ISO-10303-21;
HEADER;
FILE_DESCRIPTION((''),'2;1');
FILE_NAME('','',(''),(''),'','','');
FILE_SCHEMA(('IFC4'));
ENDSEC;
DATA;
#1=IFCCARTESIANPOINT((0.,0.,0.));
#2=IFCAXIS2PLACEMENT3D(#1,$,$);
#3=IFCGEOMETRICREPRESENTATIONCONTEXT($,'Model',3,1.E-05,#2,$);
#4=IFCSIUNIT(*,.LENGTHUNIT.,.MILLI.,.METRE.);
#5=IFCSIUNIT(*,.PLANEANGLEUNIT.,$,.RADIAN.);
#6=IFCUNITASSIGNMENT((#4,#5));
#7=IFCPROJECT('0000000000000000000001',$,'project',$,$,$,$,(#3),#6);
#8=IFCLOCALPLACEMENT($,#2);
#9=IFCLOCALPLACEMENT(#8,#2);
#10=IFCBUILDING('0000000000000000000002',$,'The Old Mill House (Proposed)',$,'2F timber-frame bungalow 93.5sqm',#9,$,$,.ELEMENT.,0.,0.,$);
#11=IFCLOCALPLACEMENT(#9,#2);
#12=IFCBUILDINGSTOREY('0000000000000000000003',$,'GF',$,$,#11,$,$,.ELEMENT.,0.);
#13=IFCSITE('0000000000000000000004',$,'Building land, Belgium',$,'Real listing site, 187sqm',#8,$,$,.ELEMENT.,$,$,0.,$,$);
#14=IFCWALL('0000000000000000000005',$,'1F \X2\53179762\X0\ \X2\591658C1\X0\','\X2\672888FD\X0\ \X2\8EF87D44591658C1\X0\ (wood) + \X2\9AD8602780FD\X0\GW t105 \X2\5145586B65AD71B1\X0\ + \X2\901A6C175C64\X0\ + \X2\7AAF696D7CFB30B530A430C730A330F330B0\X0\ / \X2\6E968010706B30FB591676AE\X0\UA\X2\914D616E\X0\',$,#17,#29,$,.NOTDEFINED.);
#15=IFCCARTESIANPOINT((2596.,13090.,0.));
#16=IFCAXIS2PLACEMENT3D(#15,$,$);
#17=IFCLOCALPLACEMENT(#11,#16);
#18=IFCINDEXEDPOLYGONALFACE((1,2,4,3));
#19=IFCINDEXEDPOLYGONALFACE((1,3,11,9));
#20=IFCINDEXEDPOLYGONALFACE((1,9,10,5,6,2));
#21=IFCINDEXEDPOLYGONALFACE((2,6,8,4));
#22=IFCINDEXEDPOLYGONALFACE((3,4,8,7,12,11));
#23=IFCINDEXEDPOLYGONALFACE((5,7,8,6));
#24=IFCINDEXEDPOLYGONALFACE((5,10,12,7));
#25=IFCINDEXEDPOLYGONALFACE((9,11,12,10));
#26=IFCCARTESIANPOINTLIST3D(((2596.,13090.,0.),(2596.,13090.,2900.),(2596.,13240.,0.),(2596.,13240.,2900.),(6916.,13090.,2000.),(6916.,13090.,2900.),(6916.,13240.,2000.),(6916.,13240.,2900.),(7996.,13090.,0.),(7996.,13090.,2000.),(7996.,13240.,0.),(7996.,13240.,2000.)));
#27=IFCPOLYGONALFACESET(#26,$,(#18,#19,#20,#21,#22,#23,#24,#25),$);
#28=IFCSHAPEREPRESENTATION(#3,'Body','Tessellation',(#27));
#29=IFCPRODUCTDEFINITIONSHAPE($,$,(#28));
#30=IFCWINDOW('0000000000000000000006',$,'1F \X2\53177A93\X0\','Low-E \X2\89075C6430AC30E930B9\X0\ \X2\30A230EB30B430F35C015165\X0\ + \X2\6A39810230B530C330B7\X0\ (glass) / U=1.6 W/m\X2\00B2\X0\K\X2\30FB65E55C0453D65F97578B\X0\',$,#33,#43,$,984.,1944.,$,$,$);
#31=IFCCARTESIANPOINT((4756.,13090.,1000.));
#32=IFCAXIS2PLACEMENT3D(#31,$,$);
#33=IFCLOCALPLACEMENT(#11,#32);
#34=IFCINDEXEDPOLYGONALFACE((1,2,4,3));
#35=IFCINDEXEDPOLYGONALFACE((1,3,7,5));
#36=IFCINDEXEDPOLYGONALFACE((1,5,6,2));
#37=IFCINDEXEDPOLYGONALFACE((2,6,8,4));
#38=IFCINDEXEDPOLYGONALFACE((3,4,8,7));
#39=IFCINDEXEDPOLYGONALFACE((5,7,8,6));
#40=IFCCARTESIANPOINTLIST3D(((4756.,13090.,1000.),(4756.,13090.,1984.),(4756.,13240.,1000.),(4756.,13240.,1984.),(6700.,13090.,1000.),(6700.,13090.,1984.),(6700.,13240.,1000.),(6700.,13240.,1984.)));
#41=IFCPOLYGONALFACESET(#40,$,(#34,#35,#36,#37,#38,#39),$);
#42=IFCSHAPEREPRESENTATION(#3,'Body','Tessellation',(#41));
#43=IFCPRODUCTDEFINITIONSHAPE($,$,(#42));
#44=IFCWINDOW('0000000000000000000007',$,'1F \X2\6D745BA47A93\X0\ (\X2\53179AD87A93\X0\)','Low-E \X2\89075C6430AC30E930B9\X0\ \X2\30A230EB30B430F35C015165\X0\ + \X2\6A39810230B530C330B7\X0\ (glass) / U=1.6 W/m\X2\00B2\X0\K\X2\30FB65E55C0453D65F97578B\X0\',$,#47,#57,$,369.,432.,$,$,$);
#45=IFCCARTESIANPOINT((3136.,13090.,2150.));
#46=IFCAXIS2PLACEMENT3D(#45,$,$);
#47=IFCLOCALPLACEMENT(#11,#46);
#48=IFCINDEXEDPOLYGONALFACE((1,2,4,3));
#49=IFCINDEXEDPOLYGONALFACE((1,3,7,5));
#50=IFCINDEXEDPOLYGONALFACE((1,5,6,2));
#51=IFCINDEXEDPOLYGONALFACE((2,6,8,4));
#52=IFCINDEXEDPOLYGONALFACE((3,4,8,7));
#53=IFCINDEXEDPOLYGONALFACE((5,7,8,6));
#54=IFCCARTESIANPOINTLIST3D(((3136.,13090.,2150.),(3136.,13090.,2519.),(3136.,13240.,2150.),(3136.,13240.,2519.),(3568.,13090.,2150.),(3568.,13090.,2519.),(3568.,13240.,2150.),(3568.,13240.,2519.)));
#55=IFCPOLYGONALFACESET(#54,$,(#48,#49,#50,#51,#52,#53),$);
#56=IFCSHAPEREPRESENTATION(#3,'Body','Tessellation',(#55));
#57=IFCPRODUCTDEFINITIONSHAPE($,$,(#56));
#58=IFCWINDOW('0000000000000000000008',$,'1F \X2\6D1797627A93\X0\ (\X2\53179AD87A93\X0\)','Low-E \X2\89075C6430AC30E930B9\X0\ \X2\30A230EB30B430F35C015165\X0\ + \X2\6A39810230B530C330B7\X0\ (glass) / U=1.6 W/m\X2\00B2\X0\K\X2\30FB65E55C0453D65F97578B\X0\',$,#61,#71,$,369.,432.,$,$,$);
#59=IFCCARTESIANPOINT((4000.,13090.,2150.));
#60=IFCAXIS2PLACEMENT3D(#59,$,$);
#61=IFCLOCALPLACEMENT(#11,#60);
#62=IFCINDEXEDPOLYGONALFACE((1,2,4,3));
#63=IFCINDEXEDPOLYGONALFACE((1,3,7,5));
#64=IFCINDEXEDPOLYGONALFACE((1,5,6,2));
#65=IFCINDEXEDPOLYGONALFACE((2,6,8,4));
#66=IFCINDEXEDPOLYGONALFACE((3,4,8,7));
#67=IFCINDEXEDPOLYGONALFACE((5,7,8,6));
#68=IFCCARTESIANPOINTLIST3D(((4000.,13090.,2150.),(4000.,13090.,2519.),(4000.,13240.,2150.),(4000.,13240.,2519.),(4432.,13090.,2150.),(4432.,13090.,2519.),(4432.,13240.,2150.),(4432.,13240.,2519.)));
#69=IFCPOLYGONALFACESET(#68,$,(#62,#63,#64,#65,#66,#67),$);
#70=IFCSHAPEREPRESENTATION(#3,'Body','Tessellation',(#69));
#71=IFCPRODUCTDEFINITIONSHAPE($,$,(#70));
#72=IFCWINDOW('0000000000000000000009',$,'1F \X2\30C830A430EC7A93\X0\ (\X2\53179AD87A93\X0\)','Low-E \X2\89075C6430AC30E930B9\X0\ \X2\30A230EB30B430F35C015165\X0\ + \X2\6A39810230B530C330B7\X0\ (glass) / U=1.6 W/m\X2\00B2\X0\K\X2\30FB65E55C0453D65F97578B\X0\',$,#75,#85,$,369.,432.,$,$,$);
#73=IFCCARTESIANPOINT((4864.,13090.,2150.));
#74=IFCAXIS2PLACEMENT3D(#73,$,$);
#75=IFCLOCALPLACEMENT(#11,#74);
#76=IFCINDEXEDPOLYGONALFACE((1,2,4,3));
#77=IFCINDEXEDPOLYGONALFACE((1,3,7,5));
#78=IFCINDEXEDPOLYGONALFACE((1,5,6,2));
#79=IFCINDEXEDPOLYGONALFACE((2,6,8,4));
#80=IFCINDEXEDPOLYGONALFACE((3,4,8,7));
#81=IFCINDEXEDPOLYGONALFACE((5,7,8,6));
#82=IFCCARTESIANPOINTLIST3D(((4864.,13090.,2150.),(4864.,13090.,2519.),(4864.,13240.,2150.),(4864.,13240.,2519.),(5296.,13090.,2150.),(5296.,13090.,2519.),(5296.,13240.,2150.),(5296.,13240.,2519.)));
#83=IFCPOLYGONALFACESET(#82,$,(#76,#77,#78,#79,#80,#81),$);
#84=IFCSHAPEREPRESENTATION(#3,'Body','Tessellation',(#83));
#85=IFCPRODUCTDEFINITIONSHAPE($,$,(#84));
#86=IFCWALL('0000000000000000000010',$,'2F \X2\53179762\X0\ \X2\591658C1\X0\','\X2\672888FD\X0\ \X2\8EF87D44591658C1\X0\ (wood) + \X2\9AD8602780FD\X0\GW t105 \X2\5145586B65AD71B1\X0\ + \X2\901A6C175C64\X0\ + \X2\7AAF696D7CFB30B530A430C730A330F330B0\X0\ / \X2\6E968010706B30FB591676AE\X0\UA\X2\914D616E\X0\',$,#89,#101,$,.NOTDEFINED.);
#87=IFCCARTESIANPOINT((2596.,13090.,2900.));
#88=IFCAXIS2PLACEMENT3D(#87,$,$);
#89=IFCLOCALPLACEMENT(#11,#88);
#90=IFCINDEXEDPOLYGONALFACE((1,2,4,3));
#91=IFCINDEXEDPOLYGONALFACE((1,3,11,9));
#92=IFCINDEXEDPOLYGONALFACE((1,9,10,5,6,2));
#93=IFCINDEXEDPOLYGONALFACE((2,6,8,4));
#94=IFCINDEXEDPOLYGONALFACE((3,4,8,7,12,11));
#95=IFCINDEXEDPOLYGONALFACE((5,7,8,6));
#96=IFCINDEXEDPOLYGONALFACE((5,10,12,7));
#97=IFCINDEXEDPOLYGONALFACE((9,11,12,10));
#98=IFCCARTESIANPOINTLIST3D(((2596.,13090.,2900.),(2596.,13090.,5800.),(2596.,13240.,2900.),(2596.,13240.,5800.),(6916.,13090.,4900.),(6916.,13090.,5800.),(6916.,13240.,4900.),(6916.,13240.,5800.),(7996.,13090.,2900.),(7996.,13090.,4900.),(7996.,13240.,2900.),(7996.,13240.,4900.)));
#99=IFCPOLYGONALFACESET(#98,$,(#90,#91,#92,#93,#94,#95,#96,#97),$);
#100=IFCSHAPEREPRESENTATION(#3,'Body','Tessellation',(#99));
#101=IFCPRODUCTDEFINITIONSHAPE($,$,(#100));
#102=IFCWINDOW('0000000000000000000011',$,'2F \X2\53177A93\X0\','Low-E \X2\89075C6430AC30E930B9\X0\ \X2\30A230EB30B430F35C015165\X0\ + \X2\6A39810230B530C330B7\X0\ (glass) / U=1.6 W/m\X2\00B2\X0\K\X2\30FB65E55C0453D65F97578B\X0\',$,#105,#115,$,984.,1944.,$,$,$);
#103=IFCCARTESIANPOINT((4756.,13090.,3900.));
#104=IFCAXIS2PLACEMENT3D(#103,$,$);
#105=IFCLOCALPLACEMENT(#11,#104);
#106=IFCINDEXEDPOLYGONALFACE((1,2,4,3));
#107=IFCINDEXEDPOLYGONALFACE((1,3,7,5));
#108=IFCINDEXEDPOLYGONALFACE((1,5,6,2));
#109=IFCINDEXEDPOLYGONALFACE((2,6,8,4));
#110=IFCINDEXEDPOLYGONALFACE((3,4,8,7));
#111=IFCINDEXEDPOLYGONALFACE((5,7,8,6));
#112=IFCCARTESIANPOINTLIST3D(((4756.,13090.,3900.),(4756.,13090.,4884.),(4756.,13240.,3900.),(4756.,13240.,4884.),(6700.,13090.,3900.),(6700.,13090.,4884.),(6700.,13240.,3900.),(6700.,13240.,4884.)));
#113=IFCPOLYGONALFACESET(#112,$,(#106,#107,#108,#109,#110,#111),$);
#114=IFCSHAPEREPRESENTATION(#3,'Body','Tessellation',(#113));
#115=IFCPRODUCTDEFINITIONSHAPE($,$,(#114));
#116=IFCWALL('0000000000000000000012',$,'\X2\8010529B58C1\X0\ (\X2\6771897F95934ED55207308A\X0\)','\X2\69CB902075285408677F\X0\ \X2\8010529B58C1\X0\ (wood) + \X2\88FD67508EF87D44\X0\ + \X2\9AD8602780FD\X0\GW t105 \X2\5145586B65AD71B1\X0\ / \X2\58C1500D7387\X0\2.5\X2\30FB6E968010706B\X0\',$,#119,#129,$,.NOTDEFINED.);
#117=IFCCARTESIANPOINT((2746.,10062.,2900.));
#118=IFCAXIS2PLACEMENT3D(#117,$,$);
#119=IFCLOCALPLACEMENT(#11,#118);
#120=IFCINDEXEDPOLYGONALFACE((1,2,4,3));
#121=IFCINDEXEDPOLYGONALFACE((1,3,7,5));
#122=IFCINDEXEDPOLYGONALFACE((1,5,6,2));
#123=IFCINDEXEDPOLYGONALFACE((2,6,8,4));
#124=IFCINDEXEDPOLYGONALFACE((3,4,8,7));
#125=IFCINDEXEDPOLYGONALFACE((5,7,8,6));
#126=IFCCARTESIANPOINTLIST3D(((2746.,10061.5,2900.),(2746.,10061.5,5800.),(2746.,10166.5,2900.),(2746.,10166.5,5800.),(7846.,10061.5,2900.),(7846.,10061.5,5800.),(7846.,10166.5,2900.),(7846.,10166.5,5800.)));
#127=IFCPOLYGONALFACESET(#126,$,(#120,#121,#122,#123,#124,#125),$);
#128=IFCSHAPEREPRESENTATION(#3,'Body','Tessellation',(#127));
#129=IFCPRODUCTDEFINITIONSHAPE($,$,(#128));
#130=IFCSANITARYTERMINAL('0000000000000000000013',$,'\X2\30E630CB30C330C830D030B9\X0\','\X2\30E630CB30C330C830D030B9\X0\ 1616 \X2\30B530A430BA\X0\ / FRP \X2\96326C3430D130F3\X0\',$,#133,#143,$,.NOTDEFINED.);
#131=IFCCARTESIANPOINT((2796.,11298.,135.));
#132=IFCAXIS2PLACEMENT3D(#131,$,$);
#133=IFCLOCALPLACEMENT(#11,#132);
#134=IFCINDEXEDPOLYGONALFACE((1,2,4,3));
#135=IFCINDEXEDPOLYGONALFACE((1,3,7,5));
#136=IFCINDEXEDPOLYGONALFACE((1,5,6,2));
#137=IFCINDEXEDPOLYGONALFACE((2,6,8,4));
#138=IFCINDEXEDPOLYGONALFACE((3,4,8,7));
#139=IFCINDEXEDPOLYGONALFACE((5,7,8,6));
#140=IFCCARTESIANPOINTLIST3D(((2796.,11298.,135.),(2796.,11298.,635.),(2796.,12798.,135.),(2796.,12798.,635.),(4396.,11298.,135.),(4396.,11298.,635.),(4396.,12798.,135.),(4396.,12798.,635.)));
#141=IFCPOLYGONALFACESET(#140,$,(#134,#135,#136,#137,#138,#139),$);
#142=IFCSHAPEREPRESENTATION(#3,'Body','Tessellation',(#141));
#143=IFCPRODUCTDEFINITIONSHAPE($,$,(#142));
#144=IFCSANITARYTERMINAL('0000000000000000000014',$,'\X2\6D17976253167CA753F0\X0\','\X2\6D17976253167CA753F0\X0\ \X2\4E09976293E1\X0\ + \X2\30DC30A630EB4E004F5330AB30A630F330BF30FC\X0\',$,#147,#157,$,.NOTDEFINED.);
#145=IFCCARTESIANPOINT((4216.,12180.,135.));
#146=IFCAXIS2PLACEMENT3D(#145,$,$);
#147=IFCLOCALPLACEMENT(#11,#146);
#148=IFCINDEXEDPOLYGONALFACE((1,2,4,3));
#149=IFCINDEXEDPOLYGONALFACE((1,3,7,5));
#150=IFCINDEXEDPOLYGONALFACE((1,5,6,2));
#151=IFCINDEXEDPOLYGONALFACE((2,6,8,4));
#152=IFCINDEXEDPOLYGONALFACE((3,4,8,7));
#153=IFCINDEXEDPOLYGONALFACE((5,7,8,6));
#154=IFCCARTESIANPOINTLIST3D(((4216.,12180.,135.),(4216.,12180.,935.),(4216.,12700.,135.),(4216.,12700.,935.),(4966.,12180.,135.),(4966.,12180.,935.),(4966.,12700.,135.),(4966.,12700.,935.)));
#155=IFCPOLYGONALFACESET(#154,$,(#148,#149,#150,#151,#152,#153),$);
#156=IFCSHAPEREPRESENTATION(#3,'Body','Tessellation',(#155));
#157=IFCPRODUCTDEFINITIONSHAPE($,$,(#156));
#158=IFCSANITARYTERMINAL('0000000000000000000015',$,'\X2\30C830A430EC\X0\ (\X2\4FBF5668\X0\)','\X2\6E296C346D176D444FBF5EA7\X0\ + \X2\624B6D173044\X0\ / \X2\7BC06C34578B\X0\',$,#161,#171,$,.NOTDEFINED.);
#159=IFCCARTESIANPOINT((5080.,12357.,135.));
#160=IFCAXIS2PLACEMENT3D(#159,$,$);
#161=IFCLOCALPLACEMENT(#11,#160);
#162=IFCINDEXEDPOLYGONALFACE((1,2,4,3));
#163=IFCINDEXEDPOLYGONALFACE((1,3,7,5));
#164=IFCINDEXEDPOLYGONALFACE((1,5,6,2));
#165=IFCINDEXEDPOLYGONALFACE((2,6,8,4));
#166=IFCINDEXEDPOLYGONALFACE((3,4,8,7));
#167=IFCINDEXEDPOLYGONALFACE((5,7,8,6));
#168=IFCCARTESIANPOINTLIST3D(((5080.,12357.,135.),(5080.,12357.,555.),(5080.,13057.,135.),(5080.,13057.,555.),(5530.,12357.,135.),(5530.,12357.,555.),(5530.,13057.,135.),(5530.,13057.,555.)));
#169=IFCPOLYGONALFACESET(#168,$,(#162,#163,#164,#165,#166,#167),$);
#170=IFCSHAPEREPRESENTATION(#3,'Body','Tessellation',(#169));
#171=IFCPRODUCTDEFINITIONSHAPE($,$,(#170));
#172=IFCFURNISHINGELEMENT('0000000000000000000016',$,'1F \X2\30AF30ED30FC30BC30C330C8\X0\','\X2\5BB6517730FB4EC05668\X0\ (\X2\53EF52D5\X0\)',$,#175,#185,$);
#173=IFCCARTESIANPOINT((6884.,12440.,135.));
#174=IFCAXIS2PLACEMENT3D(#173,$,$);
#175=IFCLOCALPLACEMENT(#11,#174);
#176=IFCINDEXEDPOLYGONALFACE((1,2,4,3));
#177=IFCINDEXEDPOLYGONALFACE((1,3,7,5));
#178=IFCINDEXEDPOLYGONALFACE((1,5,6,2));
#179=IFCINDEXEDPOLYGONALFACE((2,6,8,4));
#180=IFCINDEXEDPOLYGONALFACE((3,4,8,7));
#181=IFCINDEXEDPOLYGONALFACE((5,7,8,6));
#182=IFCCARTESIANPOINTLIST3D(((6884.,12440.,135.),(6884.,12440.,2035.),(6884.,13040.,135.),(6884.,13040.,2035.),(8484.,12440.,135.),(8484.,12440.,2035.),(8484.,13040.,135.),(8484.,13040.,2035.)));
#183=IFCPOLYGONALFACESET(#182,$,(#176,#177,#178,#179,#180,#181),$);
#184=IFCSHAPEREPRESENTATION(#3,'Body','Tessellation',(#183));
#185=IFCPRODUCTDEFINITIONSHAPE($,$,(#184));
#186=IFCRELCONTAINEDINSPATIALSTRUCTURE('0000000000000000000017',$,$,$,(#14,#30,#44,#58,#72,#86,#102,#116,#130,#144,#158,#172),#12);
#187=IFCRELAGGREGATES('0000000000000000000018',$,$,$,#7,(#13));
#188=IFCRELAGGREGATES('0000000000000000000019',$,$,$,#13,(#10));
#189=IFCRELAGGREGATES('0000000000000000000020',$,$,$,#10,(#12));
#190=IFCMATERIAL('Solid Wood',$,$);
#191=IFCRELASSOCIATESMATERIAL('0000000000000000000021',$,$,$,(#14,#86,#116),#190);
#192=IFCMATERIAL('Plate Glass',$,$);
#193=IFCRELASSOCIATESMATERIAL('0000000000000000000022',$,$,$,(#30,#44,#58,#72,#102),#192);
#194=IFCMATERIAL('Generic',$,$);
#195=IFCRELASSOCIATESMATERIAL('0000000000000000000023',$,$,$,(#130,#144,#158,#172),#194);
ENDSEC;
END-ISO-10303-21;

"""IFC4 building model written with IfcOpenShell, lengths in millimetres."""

from ifc_helpers import new_model, si_unit, frame, frame_2d, origin, place, context, project, spatial, rectangle, extrude, material, element, fill, save


model = new_model("IFC4")

# Units and contexts
model_context = context("Model", 3, precision=1e-05, world=origin())
ifc_project = project(units=[si_unit("LENGTHUNIT", "METRE", prefix="MILLI"), si_unit("PLANEANGLEUNIT", "RADIAN")], contexts=[model_context])

# Site, building, storey
site_placement = place(None, origin())
site = spatial("IfcSite", under=ifc_project, at=site_placement, Name="Building land, Belgium", ObjectType="Real listing site, 187sqm", CompositionType="ELEMENT", RefElevation=0.0)
building_placement = place(site_placement, origin())
building = spatial("IfcBuilding", under=site, at=building_placement, Name="The Old Mill House (Proposed)", ObjectType="2F timber-frame bungalow 93.5sqm", CompositionType="ELEMENT", ElevationOfRefHeight=0.0, ElevationOfTerrain=0.0)
storey_placement = place(building_placement, origin())
storey = spatial("IfcBuildingStorey", under=building, at=storey_placement, Name="GF", CompositionType="ELEMENT", Elevation=0.0)

# Wall, openings, windows
ifc_material_1 = material(Name="Solid Wood")
wall_1_placement = place(storey_placement, frame((2596.0, 13090.0, 0.0)))
wall_1 = element("IfcWall", 1, at=wall_1_placement, inside=storey, material=ifc_material_1, Name="1F 北面 外壁", Description="木製 軸組外壁 (wood) + 高性能GW t105 充填断熱 + 通気層 + 窯業系サイディング / 準耐火・外皮UA配慮", PredefinedType="NOTDEFINED", context=model_context, shape_type="SweptSolid", body=[
    extrude(rectangle(XDim=5400.0, YDim=150.0, at=frame_2d((2700.0, 75.0))), frame((2596.0, 13090.0, 0.0)), (0.0, 0.0, 1.0), 2900.0),
])
opening_1_placement = place(storey_placement, frame((4756.0, 13090.0, 1000.0)))
opening_1 = element("IfcOpeningElement", 2, at=opening_1_placement, cuts=wall_1, PredefinedType="NOTDEFINED", context=model_context, shape_type="SweptSolid", body=[
    extrude(rectangle(XDim=1944.0, YDim=150.0, at=frame_2d((972.0, 75.0))), frame((4756.0, 13090.0, 1000.0)), (0.0, 0.0, 1.0), 984.0),
])
opening_2_placement = place(storey_placement, frame((3136.0, 13090.0, 2150.0)))
opening_2 = element("IfcOpeningElement", 3, at=opening_2_placement, cuts=wall_1, PredefinedType="NOTDEFINED", context=model_context, shape_type="SweptSolid", body=[
    extrude(rectangle(XDim=432.0, YDim=150.0, at=frame_2d((216.0, 75.0))), frame((3136.0, 13090.0, 2150.0)), (0.0, 0.0, 1.0), 369.0),
])
opening_3_placement = place(storey_placement, frame((4000.0, 13090.0, 2150.0)))
opening_3 = element("IfcOpeningElement", 4, at=opening_3_placement, cuts=wall_1, PredefinedType="NOTDEFINED", context=model_context, shape_type="SweptSolid", body=[
    extrude(rectangle(XDim=432.0, YDim=150.0, at=frame_2d((216.0, 75.0))), frame((4000.0, 13090.0, 2150.0)), (0.0, 0.0, 1.0), 369.0),
])
opening_4_placement = place(storey_placement, frame((4864.0, 13090.0, 2150.0)))
opening_4 = element("IfcOpeningElement", 5, at=opening_4_placement, cuts=wall_1, PredefinedType="NOTDEFINED", context=model_context, shape_type="SweptSolid", body=[
    extrude(rectangle(XDim=432.0, YDim=150.0, at=frame_2d((216.0, 75.0))), frame((4864.0, 13090.0, 2150.0)), (0.0, 0.0, 1.0), 369.0),
])
ifc_material_2 = material(Name="Plate Glass")
window_1_placement = place(storey_placement, frame((4756.0, 13090.0, 1000.0)))
window_1 = element("IfcWindow", 6, at=window_1_placement, inside=storey, material=ifc_material_2, Name="1F 北窓", Description="Low-E 複層ガラス アルゴン封入 + 樹脂サッシ (glass) / U=1.6 W/m²K・日射取得型", OverallHeight=984.0, OverallWidth=1944.0, context=model_context, shape_type="SweptSolid", body=[
    extrude(rectangle(XDim=1944.0, YDim=150.0, at=frame_2d((972.0, 75.0))), frame((4756.0, 13090.0, 1000.0)), (0.0, 0.0, 1.0), 984.0),
])
fill(opening_1, window_1)
window_2_placement = place(storey_placement, frame((3136.0, 13090.0, 2150.0)))
window_2 = element("IfcWindow", 7, at=window_2_placement, inside=storey, material=ifc_material_2, Name="1F 浴室窓 (北高窓)", Description="Low-E 複層ガラス アルゴン封入 + 樹脂サッシ (glass) / U=1.6 W/m²K・日射取得型", OverallHeight=369.0, OverallWidth=432.0, context=model_context, shape_type="SweptSolid", body=[
    extrude(rectangle(XDim=432.0, YDim=150.0, at=frame_2d((216.0, 75.0))), frame((3136.0, 13090.0, 2150.0)), (0.0, 0.0, 1.0), 369.0),
])
fill(opening_2, window_2)
window_3_placement = place(storey_placement, frame((4000.0, 13090.0, 2150.0)))
window_3 = element("IfcWindow", 8, at=window_3_placement, inside=storey, material=ifc_material_2, Name="1F 洗面窓 (北高窓)", Description="Low-E 複層ガラス アルゴン封入 + 樹脂サッシ (glass) / U=1.6 W/m²K・日射取得型", OverallHeight=369.0, OverallWidth=432.0, context=model_context, shape_type="SweptSolid", body=[
    extrude(rectangle(XDim=432.0, YDim=150.0, at=frame_2d((216.0, 75.0))), frame((4000.0, 13090.0, 2150.0)), (0.0, 0.0, 1.0), 369.0),
])
fill(opening_3, window_3)
window_4_placement = place(storey_placement, frame((4864.0, 13090.0, 2150.0)))
window_4 = element("IfcWindow", 9, at=window_4_placement, inside=storey, material=ifc_material_2, Name="1F トイレ窓 (北高窓)", Description="Low-E 複層ガラス アルゴン封入 + 樹脂サッシ (glass) / U=1.6 W/m²K・日射取得型", OverallHeight=369.0, OverallWidth=432.0, context=model_context, shape_type="SweptSolid", body=[
    extrude(rectangle(XDim=432.0, YDim=150.0, at=frame_2d((216.0, 75.0))), frame((4864.0, 13090.0, 2150.0)), (0.0, 0.0, 1.0), 369.0),
])
fill(opening_4, window_4)

# Wall, opening, window
wall_2_placement = place(storey_placement, frame((2596.0, 13090.0, 2900.0)))
wall_2 = element("IfcWall", 10, at=wall_2_placement, inside=storey, material=ifc_material_1, Name="2F 北面 外壁", Description="木製 軸組外壁 (wood) + 高性能GW t105 充填断熱 + 通気層 + 窯業系サイディング / 準耐火・外皮UA配慮", PredefinedType="NOTDEFINED", context=model_context, shape_type="SweptSolid", body=[
    extrude(rectangle(XDim=5400.0, YDim=150.0, at=frame_2d((2700.0, 75.0))), frame((2596.0, 13090.0, 2900.0)), (0.0, 0.0, 1.0), 2900.0),
])
opening_5_placement = place(storey_placement, frame((4756.0, 13090.0, 3900.0)))
opening_5 = element("IfcOpeningElement", 11, at=opening_5_placement, cuts=wall_2, PredefinedType="NOTDEFINED", context=model_context, shape_type="SweptSolid", body=[
    extrude(rectangle(XDim=1944.0, YDim=150.0, at=frame_2d((972.0, 75.0))), frame((4756.0, 13090.0, 3900.0)), (0.0, 0.0, 1.0), 984.0),
])
window_5_placement = place(storey_placement, frame((4756.0, 13090.0, 3900.0)))
window_5 = element("IfcWindow", 12, at=window_5_placement, inside=storey, material=ifc_material_2, Name="2F 北窓", Description="Low-E 複層ガラス アルゴン封入 + 樹脂サッシ (glass) / U=1.6 W/m²K・日射取得型", OverallHeight=984.0, OverallWidth=1944.0, context=model_context, shape_type="SweptSolid", body=[
    extrude(rectangle(XDim=1944.0, YDim=150.0, at=frame_2d((972.0, 75.0))), frame((4756.0, 13090.0, 3900.0)), (0.0, 0.0, 1.0), 984.0),
])
fill(opening_5, window_5)

# Wall
wall_3_placement = place(storey_placement, frame((2746.0, 10062.0, 2900.0)))
element("IfcWall", 13, at=wall_3_placement, inside=storey, material=ifc_material_1, Name="耐力壁 (東西間仕切り)", Description="構造用合板 耐力壁 (wood) + 製材軸組 + 高性能GW t105 充填断熱 / 壁倍率2.5・準耐火", PredefinedType="NOTDEFINED", context=model_context, shape_type="SweptSolid", body=[
    extrude(rectangle(XDim=5100.0, YDim=105.0, at=frame_2d((2550.0, 52.0))), frame((2746.0, 10062.0, 2900.0)), (0.0, 0.0, 1.0), 2900.0),
])

# Sanitary terminals
ifc_material_3 = material(Name="Generic")
sanitary_terminal_1_placement = place(storey_placement, frame((2796.0, 11298.0, 135.0)))
element("IfcSanitaryTerminal", 14, at=sanitary_terminal_1_placement, inside=storey, material=ifc_material_3, Name="ユニットバス", Description="ユニットバス 1616 サイズ / FRP 防水パン", PredefinedType="NOTDEFINED", context=model_context, shape_type="SweptSolid", body=[
    extrude(rectangle(XDim=1600.0, YDim=1500.0, at=frame_2d((800.0, 750.0))), frame((2796.0, 11298.0, 135.0)), (0.0, 0.0, 1.0), 500.0),
])
sanitary_terminal_2_placement = place(storey_placement, frame((4216.0, 12180.0, 135.0)))
element("IfcSanitaryTerminal", 15, at=sanitary_terminal_2_placement, inside=storey, material=ifc_material_3, Name="洗面化粧台", Description="洗面化粧台 三面鏡 + ボウル一体カウンター", PredefinedType="NOTDEFINED", context=model_context, shape_type="SweptSolid", body=[
    extrude(rectangle(XDim=750.0, YDim=520.0, at=frame_2d((375.0, 260.0))), frame((4216.0, 12180.0, 135.0)), (0.0, 0.0, 1.0), 800.0),
])
sanitary_terminal_3_placement = place(storey_placement, frame((5080.0, 12357.0, 135.0)))
element("IfcSanitaryTerminal", 16, at=sanitary_terminal_3_placement, inside=storey, material=ifc_material_3, Name="トイレ (便器)", Description="温水洗浄便座 + 手洗い / 節水型", PredefinedType="NOTDEFINED", context=model_context, shape_type="SweptSolid", body=[
    extrude(rectangle(XDim=450.0, YDim=700.0, at=frame_2d((225.0, 350.0))), frame((5080.0, 12357.0, 135.0)), (0.0, 0.0, 1.0), 420.0),
])

# Furnishing element
furnishing_1_placement = place(storey_placement, frame((6884.0, 12440.0, 135.0)))
element("IfcFurnishingElement", 17, at=furnishing_1_placement, inside=storey, material=ifc_material_3, Name="1F クローゼット", Description="家具・什器 (可動)", context=model_context, shape_type="SweptSolid", body=[
    extrude(rectangle(XDim=1600.0, YDim=600.0, at=frame_2d((800.0, 300.0))), frame((6884.0, 12440.0, 135.0)), (0.0, 0.0, 1.0), 1900.0),
])

save(model, "model.ifc")
